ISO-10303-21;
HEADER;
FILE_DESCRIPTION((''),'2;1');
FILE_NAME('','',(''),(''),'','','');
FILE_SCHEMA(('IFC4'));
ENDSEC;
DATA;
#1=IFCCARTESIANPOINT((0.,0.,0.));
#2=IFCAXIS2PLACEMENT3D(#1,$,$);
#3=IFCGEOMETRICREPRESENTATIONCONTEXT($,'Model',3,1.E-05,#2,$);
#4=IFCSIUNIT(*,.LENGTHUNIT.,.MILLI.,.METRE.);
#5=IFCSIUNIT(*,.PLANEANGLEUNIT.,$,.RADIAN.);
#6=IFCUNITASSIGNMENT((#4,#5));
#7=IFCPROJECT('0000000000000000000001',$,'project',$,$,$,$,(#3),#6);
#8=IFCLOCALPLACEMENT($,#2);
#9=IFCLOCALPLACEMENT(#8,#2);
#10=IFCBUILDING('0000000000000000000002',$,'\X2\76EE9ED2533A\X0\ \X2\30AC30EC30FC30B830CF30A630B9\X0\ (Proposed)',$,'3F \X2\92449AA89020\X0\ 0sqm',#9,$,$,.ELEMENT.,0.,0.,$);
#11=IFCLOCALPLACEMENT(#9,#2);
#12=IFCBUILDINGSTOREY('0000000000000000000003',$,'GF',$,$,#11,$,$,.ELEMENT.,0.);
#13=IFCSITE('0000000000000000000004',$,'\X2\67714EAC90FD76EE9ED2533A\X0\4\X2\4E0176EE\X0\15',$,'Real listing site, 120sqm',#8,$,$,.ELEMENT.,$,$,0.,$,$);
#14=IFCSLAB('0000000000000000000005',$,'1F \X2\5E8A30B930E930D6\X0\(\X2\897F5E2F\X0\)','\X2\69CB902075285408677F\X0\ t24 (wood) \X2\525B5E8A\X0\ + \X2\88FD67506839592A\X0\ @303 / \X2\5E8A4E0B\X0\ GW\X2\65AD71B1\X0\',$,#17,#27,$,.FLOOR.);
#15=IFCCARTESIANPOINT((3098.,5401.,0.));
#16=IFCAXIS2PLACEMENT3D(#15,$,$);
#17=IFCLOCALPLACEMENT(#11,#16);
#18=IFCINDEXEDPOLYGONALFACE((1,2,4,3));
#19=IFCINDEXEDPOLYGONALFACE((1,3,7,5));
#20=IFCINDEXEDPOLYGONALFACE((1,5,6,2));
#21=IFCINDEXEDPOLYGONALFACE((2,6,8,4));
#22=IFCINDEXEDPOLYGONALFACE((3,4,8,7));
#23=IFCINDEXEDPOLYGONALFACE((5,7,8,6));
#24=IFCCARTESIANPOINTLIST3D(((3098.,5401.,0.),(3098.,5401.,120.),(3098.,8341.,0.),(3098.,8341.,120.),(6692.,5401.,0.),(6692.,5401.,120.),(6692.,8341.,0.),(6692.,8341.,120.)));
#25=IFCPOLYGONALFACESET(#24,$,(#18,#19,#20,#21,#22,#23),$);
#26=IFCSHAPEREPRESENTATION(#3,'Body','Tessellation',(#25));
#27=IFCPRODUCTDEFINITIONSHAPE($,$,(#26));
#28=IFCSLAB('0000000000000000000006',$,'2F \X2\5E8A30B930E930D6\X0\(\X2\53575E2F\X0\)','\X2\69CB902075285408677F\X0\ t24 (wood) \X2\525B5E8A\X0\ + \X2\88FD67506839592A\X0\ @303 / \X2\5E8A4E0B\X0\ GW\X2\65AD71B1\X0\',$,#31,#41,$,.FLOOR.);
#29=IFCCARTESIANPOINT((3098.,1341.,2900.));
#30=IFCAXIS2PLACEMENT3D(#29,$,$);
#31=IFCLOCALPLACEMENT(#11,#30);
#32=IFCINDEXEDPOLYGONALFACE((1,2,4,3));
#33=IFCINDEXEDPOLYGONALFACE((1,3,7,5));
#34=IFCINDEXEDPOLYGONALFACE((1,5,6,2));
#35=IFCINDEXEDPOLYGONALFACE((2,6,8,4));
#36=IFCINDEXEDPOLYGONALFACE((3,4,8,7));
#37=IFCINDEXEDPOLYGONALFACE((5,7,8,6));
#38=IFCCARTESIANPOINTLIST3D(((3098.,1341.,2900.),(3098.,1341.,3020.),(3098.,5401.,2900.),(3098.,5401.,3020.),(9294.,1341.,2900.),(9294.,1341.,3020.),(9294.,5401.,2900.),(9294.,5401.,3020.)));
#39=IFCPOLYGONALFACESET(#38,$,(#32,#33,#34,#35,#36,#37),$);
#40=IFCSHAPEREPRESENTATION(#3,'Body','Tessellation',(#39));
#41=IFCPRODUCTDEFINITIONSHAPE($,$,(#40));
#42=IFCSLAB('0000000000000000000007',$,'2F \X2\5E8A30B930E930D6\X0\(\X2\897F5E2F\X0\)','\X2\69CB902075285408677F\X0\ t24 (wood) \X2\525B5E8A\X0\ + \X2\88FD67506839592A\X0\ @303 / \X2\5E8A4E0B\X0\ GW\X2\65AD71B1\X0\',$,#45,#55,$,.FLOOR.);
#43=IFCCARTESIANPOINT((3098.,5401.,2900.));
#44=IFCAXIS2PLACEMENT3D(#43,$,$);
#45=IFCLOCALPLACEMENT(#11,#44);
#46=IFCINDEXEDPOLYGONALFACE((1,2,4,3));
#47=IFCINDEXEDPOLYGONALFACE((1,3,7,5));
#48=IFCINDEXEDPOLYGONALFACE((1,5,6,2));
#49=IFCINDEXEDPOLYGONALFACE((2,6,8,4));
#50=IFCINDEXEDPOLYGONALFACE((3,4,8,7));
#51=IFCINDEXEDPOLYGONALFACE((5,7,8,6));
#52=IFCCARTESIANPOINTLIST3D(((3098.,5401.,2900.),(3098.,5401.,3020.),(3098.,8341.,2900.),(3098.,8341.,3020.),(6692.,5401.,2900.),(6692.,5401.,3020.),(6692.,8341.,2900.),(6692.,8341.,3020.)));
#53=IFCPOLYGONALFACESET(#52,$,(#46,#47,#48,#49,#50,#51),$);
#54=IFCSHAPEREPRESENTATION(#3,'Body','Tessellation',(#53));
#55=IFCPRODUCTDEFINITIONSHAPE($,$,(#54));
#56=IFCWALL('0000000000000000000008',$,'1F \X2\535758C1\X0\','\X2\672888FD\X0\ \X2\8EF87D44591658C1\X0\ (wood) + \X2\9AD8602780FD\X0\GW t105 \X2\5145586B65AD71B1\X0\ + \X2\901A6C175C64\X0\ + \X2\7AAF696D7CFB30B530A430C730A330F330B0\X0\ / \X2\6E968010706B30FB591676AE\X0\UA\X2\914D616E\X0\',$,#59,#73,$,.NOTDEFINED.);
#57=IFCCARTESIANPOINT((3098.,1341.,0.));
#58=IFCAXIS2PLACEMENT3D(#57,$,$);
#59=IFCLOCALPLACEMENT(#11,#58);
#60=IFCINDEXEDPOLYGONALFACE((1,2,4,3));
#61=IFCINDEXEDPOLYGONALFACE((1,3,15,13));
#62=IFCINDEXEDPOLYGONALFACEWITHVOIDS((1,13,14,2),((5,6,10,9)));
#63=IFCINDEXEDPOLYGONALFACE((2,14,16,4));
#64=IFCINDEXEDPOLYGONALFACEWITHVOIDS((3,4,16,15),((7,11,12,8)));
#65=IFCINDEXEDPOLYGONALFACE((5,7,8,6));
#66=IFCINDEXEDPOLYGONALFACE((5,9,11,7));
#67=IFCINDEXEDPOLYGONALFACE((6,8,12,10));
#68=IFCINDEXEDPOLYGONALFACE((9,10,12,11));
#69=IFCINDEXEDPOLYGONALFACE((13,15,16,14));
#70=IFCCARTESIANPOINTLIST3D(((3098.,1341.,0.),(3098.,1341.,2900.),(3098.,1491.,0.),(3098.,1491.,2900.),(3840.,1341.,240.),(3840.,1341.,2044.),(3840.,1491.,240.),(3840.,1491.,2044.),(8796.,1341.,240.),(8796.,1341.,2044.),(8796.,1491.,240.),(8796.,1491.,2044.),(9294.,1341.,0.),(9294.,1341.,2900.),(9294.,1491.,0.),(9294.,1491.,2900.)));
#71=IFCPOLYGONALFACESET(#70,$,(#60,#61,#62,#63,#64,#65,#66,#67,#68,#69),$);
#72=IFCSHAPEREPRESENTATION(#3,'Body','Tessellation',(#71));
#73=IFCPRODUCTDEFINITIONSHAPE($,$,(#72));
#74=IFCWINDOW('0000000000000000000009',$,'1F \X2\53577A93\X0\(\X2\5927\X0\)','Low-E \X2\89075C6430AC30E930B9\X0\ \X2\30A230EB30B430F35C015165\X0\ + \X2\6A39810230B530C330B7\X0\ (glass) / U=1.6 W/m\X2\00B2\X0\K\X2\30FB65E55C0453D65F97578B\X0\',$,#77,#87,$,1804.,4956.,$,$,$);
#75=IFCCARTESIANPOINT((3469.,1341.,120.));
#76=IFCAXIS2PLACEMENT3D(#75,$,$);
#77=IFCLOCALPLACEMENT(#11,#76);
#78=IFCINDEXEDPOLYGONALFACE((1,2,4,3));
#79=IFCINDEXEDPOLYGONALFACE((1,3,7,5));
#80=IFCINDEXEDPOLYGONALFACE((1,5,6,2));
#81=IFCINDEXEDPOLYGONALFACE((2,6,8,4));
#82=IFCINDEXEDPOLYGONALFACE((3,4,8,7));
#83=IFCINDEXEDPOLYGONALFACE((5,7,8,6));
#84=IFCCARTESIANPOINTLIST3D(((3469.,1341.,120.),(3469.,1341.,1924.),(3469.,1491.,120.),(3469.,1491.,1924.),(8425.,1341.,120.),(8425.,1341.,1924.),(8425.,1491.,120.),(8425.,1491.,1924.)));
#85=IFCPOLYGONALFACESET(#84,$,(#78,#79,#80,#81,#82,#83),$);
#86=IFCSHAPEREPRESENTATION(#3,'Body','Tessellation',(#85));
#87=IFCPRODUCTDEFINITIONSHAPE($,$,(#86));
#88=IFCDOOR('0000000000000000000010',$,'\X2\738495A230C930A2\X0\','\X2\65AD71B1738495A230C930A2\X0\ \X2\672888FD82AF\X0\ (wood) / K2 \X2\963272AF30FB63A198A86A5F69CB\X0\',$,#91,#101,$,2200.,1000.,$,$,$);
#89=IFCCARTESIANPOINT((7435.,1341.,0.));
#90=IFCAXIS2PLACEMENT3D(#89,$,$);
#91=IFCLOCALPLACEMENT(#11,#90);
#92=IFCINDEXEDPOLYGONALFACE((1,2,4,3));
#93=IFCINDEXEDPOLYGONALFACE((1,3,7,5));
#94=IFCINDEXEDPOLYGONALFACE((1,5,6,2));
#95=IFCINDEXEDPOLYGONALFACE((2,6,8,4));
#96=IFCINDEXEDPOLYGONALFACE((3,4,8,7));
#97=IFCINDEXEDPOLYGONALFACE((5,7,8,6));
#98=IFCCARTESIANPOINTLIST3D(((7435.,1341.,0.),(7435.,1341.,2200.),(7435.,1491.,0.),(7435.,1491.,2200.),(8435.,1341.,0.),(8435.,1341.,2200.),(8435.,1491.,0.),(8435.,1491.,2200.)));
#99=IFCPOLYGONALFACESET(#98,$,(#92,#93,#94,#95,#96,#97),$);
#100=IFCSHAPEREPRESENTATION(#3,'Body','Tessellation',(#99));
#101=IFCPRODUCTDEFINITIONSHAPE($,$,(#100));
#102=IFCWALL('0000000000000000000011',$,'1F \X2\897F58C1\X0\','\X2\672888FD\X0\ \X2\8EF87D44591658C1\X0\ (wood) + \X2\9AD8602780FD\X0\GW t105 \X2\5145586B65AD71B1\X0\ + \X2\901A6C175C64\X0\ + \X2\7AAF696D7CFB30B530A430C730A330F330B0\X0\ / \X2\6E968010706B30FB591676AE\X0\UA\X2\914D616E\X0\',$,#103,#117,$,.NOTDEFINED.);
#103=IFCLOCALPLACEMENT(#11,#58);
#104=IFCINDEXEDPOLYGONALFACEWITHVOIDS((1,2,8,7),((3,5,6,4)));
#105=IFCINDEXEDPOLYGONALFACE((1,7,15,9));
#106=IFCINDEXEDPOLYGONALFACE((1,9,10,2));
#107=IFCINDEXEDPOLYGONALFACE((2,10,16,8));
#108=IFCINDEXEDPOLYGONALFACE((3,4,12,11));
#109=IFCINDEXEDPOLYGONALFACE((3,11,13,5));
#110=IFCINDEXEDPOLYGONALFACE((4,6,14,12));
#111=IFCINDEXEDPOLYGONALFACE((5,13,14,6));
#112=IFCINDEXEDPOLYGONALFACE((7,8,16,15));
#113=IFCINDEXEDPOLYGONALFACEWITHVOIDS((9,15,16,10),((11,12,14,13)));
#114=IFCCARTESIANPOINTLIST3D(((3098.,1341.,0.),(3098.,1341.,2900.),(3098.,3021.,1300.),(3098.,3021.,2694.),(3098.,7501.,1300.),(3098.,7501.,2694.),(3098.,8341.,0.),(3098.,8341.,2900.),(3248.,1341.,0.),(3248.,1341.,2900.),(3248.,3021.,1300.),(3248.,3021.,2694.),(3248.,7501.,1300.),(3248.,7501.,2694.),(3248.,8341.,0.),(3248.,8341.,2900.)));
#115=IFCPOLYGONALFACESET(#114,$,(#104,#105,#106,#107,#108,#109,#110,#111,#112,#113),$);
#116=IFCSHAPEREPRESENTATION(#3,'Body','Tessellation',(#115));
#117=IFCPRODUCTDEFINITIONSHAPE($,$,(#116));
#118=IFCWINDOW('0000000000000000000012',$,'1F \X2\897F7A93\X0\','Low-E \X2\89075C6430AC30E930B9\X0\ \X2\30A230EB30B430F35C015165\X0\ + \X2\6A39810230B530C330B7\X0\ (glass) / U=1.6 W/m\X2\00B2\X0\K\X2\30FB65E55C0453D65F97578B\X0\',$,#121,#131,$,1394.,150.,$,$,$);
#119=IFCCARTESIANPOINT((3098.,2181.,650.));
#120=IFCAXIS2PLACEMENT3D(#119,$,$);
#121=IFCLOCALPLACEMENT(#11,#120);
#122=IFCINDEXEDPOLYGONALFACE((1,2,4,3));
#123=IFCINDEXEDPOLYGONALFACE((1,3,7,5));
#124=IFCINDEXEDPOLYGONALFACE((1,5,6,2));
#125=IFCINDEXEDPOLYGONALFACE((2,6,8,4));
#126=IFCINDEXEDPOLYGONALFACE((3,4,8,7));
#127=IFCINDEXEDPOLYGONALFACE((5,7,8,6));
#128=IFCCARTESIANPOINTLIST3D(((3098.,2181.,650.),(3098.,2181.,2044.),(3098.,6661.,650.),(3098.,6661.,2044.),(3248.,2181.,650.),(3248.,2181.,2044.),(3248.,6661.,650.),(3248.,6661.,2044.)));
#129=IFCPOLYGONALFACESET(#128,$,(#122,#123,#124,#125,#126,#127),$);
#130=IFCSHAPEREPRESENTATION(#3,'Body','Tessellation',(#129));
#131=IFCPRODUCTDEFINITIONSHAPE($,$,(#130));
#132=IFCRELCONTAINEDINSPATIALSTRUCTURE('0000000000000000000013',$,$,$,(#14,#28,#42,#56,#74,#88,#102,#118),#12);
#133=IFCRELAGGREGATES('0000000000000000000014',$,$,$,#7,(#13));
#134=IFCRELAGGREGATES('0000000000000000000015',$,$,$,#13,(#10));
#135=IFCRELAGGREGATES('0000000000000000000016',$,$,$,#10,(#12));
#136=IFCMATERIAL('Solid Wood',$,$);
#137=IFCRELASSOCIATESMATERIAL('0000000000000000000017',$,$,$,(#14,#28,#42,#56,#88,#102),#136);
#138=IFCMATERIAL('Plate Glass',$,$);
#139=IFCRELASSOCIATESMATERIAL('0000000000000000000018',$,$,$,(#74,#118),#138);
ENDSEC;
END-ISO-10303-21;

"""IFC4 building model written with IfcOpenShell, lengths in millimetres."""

from ifc_helpers import new_model, si_unit, frame, frame_2d, origin, place, context, project, spatial, rectangle, extrude, material, element, fill, save


model = new_model("IFC4")

# Units and contexts
model_context = context("Model", 3, precision=1e-05, world=origin())
ifc_project = project(units=[si_unit("LENGTHUNIT", "METRE", prefix="MILLI"), si_unit("PLANEANGLEUNIT", "RADIAN")], contexts=[model_context])

# Site, building, storey
site_placement = place(None, origin())
site = spatial("IfcSite", under=ifc_project, at=site_placement, Name="東京都目黒区4丁目15", ObjectType="Real listing site, 120sqm", CompositionType="ELEMENT", RefElevation=0.0)
building_placement = place(site_placement, origin())
building = spatial("IfcBuilding", under=site, at=building_placement, Name="目黒区 ガレージハウス (Proposed)", ObjectType="3F 鉄骨造 0sqm", CompositionType="ELEMENT", ElevationOfRefHeight=0.0, ElevationOfTerrain=0.0)
storey_placement = place(building_placement, origin())
storey = spatial("IfcBuildingStorey", under=building, at=storey_placement, Name="GF", CompositionType="ELEMENT", Elevation=0.0)

# Slabs
ifc_material_1 = material(Name="Solid Wood")
slab_1_placement = place(storey_placement, frame((3098.0, 5401.0, 0.0)))
element("IfcSlab", 1, at=slab_1_placement, inside=storey, material=ifc_material_1, Name="1F 床スラブ(西帯)", Description="構造用合板 t24 (wood) 剛床 + 製材根太 @303 / 床下 GW断熱", PredefinedType="FLOOR", context=model_context, shape_type="SweptSolid", body=[
    extrude(rectangle(XDim=3594.0, YDim=2940.0, at=frame_2d((1797.0, 1470.0))), frame((3098.0, 5401.0, 0.0)), (0.0, 0.0, 1.0), 120.0),
])
slab_2_placement = place(storey_placement, frame((3098.0, 1341.0, 2900.0)))
element("IfcSlab", 2, at=slab_2_placement, inside=storey, material=ifc_material_1, Name="2F 床スラブ(南帯)", Description="構造用合板 t24 (wood) 剛床 + 製材根太 @303 / 床下 GW断熱", PredefinedType="FLOOR", context=model_context, shape_type="SweptSolid", body=[
    extrude(rectangle(XDim=6196.0, YDim=4060.0, at=frame_2d((3098.0, 2030.0))), frame((3098.0, 1341.0, 2900.0)), (0.0, 0.0, 1.0), 120.0),
])
slab_3_placement = place(storey_placement, frame((3098.0, 5401.0, 2900.0)))
element("IfcSlab", 3, at=slab_3_placement, inside=storey, material=ifc_material_1, Name="2F 床スラブ(西帯)", Description="構造用合板 t24 (wood) 剛床 + 製材根太 @303 / 床下 GW断熱", PredefinedType="FLOOR", context=model_context, shape_type="SweptSolid", body=[
    extrude(rectangle(XDim=3594.0, YDim=2940.0, at=frame_2d((1797.0, 1470.0))), frame((3098.0, 5401.0, 2900.0)), (0.0, 0.0, 1.0), 120.0),
])

# Wall, openings, window, door
wall_1_placement = place(storey_placement, frame((3098.0, 1341.0, 0.0)))
wall_1 = element("IfcWall", 4, at=wall_1_placement, inside=storey, material=ifc_material_1, Name="1F 南壁", Description="木製 軸組外壁 (wood) + 高性能GW t105 充填断熱 + 通気層 + 窯業系サイディング / 準耐火・外皮UA配慮", PredefinedType="NOTDEFINED", context=model_context, shape_type="SweptSolid", body=[
    extrude(rectangle(XDim=6196.0, YDim=150.0, at=frame_2d((3098.0, 75.0))), frame((3098.0, 1341.0, 0.0)), (0.0, 0.0, 1.0), 2900.0),
])
opening_1_placement = place(storey_placement, frame((3469.0, 1341.0, 120.0)))
opening_1 = element("IfcOpeningElement", 5, at=opening_1_placement, cuts=wall_1, PredefinedType="NOTDEFINED", context=model_context, shape_type="SweptSolid", body=[
    extrude(rectangle(XDim=4956.0, YDim=150.0, at=frame_2d((2478.0, 75.0))), frame((3469.0, 1341.0, 120.0)), (0.0, 0.0, 1.0), 1804.0),
])
opening_2_placement = place(storey_placement, frame((7435.0, 1341.0, 0.0)))
opening_2 = element("IfcOpeningElement", 6, at=opening_2_placement, cuts=wall_1, PredefinedType="NOTDEFINED", context=model_context, shape_type="SweptSolid", body=[
    extrude(rectangle(XDim=1000.0, YDim=150.0, at=frame_2d((500.0, 75.0))), frame((7435.0, 1341.0, 0.0)), (0.0, 0.0, 1.0), 2200.0),
])
ifc_material_2 = material(Name="Plate Glass")
window_1_placement = place(storey_placement, frame((3469.0, 1341.0, 120.0)))
window_1 = element("IfcWindow", 7, at=window_1_placement, inside=storey, material=ifc_material_2, Name="1F 南窓(大)", Description="Low-E 複層ガラス アルゴン封入 + 樹脂サッシ (glass) / U=1.6 W/m²K・日射取得型", OverallHeight=1804.0, OverallWidth=4956.0, context=model_context, shape_type="SweptSolid", body=[
    extrude(rectangle(XDim=4956.0, YDim=150.0, at=frame_2d((2478.0, 75.0))), frame((3469.0, 1341.0, 120.0)), (0.0, 0.0, 1.0), 1804.0),
])
fill(opening_1, window_1)
door_placement = place(storey_placement, frame((7435.0, 1341.0, 0.0)))
door = element("IfcDoor", 8, at=door_placement, inside=storey, material=ifc_material_1, Name="玄関ドア", Description="断熱玄関ドア 木製芯 (wood) / K2 防犯・採風機構", OverallHeight=2200.0, OverallWidth=1000.0, context=model_context, shape_type="SweptSolid", body=[
    extrude(rectangle(XDim=1000.0, YDim=150.0, at=frame_2d((500.0, 75.0))), frame((7435.0, 1341.0, 0.0)), (0.0, 0.0, 1.0), 2200.0),
])
fill(opening_2, door)

# Wall, opening, window
wall_2_placement = place(storey_placement, frame((3098.0, 1341.0, 0.0)))
wall_2 = element("IfcWall", 9, at=wall_2_placement, inside=storey, material=ifc_material_1, Name="1F 西壁", Description="木製 軸組外壁 (wood) + 高性能GW t105 充填断熱 + 通気層 + 窯業系サイディング / 準耐火・外皮UA配慮", PredefinedType="NOTDEFINED", context=model_context, shape_type="SweptSolid", body=[
    extrude(rectangle(XDim=150.0, YDim=7000.0, at=frame_2d((75.0, 3500.0))), frame((3098.0, 1341.0, 0.0)), (0.0, 0.0, 1.0), 2900.0),
])
opening_3_placement = place(storey_placement, frame((3098.0, 2181.0, 650.0)))
opening_3 = element("IfcOpeningElement", 10, at=opening_3_placement, cuts=wall_2, PredefinedType="NOTDEFINED", context=model_context, shape_type="SweptSolid", body=[
    extrude(rectangle(XDim=150.0, YDim=4480.0, at=frame_2d((75.0, 2240.0))), frame((3098.0, 2181.0, 650.0)), (0.0, 0.0, 1.0), 1394.0),
])
window_2_placement = place(storey_placement, frame((3098.0, 2181.0, 650.0)))
window_2 = element("IfcWindow", 11, at=window_2_placement, inside=storey, material=ifc_material_2, Name="1F 西窓", Description="Low-E 複層ガラス アルゴン封入 + 樹脂サッシ (glass) / U=1.6 W/m²K・日射取得型", OverallHeight=1394.0, OverallWidth=150.0, context=model_context, shape_type="SweptSolid", body=[
    extrude(rectangle(XDim=150.0, YDim=4480.0, at=frame_2d((75.0, 2240.0))), frame((3098.0, 2181.0, 650.0)), (0.0, 0.0, 1.0), 1394.0),
])
fill(opening_3, window_2)

save(model, "model.ifc")
